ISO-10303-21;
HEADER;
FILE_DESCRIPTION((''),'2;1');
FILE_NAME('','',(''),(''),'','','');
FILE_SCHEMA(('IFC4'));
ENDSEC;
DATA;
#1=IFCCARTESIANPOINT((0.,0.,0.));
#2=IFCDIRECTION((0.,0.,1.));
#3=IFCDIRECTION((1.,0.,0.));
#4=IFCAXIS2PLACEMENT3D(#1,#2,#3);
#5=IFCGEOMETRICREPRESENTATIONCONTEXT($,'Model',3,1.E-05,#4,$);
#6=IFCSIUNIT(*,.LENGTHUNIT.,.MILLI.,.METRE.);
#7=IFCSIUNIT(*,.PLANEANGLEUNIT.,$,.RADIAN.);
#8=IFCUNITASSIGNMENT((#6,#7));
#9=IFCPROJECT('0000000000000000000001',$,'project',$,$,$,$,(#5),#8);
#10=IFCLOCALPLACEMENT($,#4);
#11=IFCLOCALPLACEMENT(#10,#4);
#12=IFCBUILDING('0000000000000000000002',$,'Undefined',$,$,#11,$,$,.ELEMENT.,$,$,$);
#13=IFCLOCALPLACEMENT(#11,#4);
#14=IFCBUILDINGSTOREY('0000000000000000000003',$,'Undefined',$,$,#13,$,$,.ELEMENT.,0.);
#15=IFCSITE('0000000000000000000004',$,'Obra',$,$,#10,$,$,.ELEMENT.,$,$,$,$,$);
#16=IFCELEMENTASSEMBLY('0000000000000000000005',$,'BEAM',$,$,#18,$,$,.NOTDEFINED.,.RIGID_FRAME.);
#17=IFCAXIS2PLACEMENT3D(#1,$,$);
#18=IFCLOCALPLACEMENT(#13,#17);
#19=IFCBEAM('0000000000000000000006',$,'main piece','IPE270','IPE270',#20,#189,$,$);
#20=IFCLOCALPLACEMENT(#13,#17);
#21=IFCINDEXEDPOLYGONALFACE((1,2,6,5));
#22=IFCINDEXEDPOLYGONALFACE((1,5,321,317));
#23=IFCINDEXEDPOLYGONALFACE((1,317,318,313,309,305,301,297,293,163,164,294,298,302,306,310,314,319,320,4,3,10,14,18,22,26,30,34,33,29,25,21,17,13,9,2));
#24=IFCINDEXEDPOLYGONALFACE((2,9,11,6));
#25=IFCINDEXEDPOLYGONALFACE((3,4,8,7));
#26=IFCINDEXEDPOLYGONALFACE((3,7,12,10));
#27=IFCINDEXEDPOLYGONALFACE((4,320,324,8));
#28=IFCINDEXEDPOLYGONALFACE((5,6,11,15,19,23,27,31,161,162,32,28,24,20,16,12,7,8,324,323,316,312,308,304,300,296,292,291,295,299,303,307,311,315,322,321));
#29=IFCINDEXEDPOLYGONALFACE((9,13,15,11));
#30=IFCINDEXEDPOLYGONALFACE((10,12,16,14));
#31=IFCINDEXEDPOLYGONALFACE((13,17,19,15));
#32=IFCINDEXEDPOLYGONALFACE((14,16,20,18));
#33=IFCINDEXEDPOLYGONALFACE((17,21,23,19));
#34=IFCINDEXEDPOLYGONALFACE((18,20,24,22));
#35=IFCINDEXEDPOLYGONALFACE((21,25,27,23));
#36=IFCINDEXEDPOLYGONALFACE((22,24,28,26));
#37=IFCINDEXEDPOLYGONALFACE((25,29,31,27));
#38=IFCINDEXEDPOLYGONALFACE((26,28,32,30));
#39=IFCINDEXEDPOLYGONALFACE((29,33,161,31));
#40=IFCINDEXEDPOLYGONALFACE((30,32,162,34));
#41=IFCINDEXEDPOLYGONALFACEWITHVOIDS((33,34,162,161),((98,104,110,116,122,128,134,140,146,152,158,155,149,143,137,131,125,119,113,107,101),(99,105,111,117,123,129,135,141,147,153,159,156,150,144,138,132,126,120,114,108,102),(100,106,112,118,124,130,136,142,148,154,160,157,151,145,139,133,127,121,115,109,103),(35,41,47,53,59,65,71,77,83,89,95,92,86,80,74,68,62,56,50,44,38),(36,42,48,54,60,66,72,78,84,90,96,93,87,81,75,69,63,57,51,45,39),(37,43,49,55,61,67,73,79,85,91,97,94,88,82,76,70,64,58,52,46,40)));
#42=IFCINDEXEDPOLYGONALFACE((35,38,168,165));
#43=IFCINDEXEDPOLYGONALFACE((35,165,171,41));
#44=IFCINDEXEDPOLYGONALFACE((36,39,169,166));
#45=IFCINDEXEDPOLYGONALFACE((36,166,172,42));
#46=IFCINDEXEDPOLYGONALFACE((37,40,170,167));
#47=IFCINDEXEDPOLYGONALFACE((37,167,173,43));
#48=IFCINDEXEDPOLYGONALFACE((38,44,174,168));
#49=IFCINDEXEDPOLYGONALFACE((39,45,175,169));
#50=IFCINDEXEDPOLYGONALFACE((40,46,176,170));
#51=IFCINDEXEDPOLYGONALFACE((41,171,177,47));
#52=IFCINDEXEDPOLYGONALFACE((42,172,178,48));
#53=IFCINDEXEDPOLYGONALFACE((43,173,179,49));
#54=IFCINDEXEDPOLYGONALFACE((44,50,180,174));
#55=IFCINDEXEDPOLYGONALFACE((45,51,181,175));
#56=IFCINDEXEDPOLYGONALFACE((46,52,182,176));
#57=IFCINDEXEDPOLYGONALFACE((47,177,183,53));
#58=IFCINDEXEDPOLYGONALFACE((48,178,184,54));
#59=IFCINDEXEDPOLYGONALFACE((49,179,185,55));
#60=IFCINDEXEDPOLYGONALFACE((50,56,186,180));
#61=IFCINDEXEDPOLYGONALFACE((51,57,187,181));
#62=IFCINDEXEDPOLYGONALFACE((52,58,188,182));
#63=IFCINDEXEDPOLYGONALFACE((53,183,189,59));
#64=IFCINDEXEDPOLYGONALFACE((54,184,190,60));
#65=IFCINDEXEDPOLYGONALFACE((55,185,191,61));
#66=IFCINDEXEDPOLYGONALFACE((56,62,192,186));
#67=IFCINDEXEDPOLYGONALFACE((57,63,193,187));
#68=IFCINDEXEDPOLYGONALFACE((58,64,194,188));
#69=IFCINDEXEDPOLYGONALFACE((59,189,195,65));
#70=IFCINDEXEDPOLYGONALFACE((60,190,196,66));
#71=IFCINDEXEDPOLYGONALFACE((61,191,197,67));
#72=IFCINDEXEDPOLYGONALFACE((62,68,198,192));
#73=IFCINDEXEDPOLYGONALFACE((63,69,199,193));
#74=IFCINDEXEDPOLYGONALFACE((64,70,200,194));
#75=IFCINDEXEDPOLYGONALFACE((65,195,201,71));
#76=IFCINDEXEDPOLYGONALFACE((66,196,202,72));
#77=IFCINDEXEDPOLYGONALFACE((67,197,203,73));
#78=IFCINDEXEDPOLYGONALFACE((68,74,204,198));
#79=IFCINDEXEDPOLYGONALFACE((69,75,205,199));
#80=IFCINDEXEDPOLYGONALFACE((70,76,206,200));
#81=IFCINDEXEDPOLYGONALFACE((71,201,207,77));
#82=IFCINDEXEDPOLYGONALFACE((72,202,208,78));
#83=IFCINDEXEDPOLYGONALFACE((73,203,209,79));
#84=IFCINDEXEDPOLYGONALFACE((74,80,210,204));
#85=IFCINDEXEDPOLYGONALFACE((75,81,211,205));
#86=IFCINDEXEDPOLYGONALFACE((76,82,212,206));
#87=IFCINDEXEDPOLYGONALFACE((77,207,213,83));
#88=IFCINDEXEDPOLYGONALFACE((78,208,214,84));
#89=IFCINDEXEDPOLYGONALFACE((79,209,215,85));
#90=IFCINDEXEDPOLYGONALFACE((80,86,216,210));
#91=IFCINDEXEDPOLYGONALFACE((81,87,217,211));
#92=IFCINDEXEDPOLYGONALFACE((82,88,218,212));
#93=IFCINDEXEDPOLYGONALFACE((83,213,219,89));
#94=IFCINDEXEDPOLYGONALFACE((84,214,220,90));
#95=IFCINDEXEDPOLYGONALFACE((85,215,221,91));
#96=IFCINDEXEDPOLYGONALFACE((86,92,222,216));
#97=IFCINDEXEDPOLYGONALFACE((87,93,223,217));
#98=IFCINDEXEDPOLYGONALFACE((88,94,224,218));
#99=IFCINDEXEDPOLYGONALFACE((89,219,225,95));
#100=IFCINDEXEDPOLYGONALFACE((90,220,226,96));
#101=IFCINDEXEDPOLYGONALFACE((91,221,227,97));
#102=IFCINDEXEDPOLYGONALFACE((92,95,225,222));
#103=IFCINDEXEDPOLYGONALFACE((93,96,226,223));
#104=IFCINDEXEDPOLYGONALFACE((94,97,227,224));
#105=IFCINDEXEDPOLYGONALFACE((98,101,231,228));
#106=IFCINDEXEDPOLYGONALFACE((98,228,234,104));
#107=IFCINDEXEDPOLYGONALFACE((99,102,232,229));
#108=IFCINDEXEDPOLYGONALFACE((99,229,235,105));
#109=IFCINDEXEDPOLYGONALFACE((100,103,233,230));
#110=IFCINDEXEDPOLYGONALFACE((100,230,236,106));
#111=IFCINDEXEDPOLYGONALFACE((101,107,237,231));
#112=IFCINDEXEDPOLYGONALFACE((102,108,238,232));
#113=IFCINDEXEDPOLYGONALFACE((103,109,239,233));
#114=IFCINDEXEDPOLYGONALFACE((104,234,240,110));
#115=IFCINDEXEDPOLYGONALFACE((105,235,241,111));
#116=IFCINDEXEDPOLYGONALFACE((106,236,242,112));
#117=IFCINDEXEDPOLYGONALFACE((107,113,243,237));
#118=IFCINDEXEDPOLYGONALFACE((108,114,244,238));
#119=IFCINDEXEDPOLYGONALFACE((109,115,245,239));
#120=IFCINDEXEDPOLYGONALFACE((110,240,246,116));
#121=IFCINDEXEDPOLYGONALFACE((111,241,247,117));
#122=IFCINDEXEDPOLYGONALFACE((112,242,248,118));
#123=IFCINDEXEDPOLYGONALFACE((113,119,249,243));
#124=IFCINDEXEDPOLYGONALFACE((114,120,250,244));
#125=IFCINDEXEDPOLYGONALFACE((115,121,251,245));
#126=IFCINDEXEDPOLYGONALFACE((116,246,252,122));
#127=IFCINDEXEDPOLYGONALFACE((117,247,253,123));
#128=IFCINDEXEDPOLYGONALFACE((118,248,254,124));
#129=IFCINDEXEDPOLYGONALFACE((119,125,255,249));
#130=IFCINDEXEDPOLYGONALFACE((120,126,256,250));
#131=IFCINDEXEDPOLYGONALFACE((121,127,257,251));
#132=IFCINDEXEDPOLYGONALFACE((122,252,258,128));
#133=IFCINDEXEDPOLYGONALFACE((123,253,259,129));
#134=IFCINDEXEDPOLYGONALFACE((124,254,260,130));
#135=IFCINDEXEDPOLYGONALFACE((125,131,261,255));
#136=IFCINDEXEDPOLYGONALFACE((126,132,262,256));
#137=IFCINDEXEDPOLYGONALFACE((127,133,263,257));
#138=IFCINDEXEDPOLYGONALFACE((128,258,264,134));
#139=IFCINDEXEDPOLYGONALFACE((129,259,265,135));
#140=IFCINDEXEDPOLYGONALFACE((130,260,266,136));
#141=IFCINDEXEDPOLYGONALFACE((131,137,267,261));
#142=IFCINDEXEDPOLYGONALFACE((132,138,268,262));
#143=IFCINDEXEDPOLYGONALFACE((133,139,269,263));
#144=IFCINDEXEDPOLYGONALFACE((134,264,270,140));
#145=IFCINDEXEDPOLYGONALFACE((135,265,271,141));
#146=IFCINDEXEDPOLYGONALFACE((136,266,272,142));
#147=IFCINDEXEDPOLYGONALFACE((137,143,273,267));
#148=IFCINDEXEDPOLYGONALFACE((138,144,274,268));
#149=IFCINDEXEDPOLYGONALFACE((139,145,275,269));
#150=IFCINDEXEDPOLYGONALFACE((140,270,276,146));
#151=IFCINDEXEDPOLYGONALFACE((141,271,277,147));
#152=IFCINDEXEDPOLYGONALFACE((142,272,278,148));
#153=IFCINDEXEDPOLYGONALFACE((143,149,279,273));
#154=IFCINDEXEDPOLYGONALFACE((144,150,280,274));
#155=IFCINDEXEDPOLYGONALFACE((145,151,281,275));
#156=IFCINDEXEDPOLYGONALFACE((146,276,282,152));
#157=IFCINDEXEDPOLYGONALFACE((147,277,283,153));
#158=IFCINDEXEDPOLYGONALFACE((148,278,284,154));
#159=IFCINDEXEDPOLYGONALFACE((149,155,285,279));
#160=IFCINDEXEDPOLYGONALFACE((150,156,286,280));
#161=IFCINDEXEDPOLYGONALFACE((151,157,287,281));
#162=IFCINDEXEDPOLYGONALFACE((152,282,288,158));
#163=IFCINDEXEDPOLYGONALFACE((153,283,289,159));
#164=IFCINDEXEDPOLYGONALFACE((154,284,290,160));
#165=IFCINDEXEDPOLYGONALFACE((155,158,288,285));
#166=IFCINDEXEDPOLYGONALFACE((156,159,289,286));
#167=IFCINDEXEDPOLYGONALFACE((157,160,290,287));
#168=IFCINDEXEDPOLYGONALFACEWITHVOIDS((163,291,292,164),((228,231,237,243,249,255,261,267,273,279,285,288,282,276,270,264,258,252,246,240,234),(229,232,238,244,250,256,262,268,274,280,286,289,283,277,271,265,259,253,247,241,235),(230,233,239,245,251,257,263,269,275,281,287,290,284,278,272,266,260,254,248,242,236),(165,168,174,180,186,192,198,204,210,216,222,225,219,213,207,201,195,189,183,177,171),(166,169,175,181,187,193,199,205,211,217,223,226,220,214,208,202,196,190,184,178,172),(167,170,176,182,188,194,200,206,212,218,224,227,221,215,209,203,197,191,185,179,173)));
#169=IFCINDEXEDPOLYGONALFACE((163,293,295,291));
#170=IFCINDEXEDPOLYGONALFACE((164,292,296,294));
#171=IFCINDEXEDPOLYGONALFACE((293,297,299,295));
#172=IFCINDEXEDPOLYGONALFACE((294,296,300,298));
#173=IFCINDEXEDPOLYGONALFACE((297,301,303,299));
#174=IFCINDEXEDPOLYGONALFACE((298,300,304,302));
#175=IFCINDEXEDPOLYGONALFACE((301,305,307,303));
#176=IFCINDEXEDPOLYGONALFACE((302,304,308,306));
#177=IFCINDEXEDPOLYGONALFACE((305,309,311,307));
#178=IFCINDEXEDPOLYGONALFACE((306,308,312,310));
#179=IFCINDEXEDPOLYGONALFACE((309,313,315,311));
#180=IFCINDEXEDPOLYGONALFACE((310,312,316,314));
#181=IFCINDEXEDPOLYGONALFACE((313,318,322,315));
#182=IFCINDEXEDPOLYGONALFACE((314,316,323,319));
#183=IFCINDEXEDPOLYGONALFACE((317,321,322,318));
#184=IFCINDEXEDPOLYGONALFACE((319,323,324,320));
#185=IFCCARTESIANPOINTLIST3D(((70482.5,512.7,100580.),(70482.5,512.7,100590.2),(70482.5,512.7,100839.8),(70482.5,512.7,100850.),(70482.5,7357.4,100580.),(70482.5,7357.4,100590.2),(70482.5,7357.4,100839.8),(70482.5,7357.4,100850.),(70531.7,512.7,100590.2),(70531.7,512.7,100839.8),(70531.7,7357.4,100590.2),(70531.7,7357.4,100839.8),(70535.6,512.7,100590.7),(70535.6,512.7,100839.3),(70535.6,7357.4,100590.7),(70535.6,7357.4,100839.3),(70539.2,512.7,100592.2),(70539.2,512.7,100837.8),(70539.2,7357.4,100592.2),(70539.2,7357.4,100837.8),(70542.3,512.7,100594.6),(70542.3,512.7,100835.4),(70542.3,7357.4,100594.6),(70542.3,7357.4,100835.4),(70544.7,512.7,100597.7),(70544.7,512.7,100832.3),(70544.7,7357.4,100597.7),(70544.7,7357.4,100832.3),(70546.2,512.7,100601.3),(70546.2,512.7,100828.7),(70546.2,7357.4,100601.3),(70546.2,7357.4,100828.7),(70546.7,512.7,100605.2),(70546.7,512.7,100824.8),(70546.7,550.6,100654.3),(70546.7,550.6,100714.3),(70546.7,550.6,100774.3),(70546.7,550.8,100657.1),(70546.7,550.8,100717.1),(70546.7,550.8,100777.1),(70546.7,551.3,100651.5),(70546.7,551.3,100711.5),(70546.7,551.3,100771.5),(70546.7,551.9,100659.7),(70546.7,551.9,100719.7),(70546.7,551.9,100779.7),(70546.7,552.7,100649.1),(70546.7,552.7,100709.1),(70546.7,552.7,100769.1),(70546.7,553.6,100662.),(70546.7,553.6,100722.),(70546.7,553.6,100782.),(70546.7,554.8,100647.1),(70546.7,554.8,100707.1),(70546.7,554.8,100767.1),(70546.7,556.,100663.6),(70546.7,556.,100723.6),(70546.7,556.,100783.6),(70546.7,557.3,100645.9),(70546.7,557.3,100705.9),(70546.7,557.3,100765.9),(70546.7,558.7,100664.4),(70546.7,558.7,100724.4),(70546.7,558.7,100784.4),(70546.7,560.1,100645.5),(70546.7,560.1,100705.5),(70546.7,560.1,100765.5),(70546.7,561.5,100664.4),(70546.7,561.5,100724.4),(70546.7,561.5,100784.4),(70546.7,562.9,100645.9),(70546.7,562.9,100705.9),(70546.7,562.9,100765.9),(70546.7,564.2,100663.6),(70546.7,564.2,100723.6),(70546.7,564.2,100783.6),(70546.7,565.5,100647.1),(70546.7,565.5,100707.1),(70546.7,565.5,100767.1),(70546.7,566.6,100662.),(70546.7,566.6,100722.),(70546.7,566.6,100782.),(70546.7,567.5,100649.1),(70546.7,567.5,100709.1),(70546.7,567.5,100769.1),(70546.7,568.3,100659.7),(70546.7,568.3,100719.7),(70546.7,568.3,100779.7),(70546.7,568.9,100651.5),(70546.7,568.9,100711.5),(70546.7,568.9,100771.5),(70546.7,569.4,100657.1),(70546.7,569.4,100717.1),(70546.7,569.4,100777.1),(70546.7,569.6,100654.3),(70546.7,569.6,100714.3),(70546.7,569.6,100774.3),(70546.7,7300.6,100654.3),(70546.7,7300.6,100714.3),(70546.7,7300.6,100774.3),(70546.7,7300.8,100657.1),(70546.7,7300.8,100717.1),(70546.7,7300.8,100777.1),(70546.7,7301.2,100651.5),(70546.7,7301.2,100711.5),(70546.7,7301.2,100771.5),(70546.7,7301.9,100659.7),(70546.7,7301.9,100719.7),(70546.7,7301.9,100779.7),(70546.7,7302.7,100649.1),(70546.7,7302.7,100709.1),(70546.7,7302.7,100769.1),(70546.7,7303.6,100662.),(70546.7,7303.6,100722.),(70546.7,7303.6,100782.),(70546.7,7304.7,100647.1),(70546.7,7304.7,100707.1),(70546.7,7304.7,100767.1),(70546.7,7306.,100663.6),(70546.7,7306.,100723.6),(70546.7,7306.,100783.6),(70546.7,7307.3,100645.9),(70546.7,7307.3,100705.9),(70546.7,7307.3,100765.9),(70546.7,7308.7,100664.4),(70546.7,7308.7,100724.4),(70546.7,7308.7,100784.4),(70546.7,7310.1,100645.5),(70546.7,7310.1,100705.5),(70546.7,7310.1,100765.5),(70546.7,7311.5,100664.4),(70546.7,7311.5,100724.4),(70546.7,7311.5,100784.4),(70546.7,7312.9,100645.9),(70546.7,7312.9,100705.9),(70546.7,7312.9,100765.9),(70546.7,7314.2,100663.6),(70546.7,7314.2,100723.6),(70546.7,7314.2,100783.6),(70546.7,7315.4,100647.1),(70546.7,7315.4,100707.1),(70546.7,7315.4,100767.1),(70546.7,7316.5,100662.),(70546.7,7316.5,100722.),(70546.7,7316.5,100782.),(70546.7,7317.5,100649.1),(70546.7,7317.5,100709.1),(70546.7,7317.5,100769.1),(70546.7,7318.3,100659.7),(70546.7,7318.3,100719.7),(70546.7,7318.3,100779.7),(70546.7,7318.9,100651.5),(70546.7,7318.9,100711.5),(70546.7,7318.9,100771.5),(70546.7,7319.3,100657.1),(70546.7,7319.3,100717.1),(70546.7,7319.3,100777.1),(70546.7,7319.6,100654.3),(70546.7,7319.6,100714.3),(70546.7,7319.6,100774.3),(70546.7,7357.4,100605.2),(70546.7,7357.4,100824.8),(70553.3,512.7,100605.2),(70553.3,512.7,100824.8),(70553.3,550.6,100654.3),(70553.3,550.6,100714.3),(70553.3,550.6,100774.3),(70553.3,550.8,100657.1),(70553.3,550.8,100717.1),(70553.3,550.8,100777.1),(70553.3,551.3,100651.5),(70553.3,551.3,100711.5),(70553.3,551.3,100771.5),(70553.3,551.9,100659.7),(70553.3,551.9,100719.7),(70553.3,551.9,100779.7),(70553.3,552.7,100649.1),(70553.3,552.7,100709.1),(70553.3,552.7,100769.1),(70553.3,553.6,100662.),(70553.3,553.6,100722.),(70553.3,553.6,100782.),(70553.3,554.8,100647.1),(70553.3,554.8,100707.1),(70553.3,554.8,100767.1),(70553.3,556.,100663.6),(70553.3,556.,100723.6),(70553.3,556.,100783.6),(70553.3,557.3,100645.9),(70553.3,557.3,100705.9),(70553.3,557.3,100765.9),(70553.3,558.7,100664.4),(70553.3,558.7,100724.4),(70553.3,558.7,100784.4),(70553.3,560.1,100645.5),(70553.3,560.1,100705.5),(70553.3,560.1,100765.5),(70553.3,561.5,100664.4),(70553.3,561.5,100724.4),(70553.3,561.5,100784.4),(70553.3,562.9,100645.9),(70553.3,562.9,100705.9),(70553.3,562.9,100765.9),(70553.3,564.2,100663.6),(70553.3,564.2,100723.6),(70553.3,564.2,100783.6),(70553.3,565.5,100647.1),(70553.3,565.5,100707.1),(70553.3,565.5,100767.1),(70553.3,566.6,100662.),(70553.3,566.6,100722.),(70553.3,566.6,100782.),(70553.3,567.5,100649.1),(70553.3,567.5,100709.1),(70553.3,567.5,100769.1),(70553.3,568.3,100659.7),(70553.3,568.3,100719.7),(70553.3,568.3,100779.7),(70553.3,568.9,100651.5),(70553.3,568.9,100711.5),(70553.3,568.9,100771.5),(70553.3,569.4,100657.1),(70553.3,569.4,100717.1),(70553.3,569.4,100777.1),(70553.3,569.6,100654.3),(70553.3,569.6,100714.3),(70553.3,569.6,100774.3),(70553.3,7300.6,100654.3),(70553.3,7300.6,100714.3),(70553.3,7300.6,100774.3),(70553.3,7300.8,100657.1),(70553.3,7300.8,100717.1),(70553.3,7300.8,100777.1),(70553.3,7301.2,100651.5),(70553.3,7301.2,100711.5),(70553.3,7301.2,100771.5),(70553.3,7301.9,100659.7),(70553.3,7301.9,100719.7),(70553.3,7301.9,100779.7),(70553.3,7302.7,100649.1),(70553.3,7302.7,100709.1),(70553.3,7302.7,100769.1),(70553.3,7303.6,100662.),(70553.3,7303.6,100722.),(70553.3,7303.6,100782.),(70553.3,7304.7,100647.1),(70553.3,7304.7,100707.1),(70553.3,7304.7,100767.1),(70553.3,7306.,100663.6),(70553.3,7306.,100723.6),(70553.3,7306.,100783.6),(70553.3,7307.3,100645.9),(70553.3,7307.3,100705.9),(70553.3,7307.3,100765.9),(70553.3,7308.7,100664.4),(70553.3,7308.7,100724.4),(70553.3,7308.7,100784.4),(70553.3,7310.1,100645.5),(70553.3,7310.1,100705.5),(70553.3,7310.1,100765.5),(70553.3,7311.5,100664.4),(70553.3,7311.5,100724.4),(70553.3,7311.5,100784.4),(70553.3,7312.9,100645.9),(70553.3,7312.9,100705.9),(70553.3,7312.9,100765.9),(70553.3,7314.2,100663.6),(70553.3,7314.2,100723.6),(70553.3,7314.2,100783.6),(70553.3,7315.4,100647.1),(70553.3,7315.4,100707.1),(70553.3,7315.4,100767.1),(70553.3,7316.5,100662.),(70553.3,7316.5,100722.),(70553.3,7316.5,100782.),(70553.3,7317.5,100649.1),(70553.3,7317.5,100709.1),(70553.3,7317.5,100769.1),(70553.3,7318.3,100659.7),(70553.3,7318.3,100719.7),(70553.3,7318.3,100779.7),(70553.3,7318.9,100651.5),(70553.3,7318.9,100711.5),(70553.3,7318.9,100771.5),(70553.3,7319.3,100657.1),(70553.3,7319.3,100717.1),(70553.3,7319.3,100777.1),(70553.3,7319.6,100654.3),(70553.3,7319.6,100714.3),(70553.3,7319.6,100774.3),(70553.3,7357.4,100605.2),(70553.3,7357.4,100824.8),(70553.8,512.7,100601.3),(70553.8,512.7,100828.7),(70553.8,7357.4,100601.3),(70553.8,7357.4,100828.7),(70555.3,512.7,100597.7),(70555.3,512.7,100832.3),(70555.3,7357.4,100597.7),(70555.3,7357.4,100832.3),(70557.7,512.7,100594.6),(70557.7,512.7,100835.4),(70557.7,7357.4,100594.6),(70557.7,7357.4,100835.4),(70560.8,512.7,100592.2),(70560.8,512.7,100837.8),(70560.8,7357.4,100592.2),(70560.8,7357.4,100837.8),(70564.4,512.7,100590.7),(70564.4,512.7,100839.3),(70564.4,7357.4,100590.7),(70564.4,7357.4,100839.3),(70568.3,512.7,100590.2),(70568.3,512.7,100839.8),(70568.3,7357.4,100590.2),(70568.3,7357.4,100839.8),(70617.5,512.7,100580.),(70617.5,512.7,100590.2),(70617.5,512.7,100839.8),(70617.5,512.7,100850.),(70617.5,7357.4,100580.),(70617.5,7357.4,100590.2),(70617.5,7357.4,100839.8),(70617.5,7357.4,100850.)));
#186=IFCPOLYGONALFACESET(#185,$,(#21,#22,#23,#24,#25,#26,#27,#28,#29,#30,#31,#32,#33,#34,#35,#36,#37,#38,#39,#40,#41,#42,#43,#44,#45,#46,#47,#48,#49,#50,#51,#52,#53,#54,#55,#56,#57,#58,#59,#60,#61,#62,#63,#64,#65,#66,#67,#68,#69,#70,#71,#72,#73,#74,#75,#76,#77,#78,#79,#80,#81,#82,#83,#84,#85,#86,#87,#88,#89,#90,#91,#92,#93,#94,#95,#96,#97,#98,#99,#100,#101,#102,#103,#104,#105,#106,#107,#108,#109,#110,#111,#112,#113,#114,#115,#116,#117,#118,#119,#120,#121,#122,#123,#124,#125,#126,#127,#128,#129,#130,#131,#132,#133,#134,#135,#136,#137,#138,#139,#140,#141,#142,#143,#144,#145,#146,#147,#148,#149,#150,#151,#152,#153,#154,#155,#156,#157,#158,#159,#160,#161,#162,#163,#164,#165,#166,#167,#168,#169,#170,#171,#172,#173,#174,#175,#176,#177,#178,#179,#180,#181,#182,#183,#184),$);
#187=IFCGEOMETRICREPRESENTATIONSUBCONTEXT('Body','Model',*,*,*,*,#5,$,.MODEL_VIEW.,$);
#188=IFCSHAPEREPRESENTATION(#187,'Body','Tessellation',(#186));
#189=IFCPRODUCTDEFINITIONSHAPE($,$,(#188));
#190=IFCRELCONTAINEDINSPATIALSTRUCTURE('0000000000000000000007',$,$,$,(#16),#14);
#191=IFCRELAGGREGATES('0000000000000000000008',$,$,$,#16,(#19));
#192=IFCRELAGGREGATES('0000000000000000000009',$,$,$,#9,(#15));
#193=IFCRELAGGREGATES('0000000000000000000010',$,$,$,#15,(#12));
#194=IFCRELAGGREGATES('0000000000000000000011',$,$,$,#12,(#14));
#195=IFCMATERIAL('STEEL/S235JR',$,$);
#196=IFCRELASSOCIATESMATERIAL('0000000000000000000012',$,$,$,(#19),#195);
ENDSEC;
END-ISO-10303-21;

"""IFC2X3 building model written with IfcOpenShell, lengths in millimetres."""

from ifc_helpers import new_model, si_unit, frame, origin_with_axes, origin_2d_with_axis, place, context, subcontext, project, spatial, circle, i_section, extrude, clip, halfspace, source, transform, mapped, material, element, aggregate, save


model = new_model("IFC2X3")

# Units and contexts
model_context = context("Model", 3, precision=1e-05, world=origin_with_axes())
body_context = subcontext(model_context, "Body", "Model", "MODEL_VIEW")
ifc_project = project(units=[si_unit("LENGTHUNIT", "METRE", prefix="MILLI"), si_unit("PLANEANGLEUNIT", "RADIAN")], contexts=[model_context])

# Site, building, storey
site_placement = place(None, origin_with_axes())
site = spatial("IfcSite", under=ifc_project, at=site_placement, Name="Obra", CompositionType="ELEMENT")
building_placement = place(site_placement, origin_with_axes())
building = spatial("IfcBuilding", under=site, at=building_placement, Name="Undefined", CompositionType="ELEMENT")
storey_placement = place(building_placement, origin_with_axes())
storey = spatial("IfcBuildingStorey", under=building, at=storey_placement, Name="Undefined", CompositionType="ELEMENT", Elevation=0.0)

# Shared definitions
ifc_material = material(Name="STEEL/S235JR")
shared_shape_1 = source(origin_with_axes(), body_context, "Body", "SweptSolid", [
    extrude(circle(Radius=9.5, at=origin_2d_with_axis()), frame((0.0, -3.4, 0.0), z_axis=(0.0, 1.0, 0.0), x_axis=(1.0, 0.0, 0.0)), (0.0, 0.0, 1.0), 6.8),
])
shared_shape_2 = source(origin_with_axes(), body_context, "Body", "SweptSolid", [
    extrude(circle(Radius=9.5, at=origin_2d_with_axis()), frame((0.0, -3.4, 0.0), z_axis=(0.0, 1.0, 0.0), x_axis=(1.0, 0.0, 0.0)), (0.0, 0.0, 1.0), 6.8),
])

# Element assembly, beam, openings
assembly_1_placement = place(storey_placement, origin_with_axes())
assembly_1 = element("IfcElementAssembly", 1, at=assembly_1_placement, inside=storey, Name="BEAM", AssemblyPlace="NOTDEFINED", PredefinedType="RIGID_FRAME")
beam_1_placement = place(assembly_1_placement, frame((70550.0, 512.7, 100715.0), z_axis=(0.0, 0.0, 1.0), x_axis=(0.0, 1.0, 0.0)))
beam_1 = element("IfcBeam", 2, at=beam_1_placement, material=ifc_material, Name="main piece", Description="IPE270", ObjectType="IPE270", context=body_context, shape_type="Clipping", body=[
    clip(clip(extrude(i_section(OverallWidth=135.0, OverallDepth=270.0, WebThickness=6.6, FlangeThickness=10.2, FilletRadius=15.0, at=origin_2d_with_axis()), frame((6844.7, 0.0, 0.0), z_axis=(-1.0, 0.0, 0.0), x_axis=(0.0, -1.0, 0.0)), (0.0, 0.0, 1.0), 6844.7), halfspace(frame((-2.2, 60.0, -120.0), z_axis=(-1.0, -0.000021, 0.0), x_axis=(0.0, 0.0, 1.0)), False)), halfspace(frame((6846.9, -60.0, -120.0), z_axis=(1.0, 0.0, 0.0), x_axis=(0.0, 0.0, 1.0)), False)),
])
opening_1_placement = place(assembly_1_placement, frame((70550.0, 510.1, 100835.0), z_axis=(-0.000002, 1.0, 0.0), x_axis=(0.0, 0.0, -1.0)))
element("IfcOpeningElement", 3, at=opening_1_placement, cuts=beam_1, ObjectType="Opening", context=body_context, shape_type="MappedRepresentation", body=[
    mapped(shared_shape_1, transform((60.0, 0.0, 50.0))),
    mapped(shared_shape_1, transform((120.0, 0.0, 50.0))),
    mapped(shared_shape_1, transform((180.0, 0.0, 50.0))),
])
opening_2_placement = place(assembly_1_placement, frame((70550.0, 7360.1, 100835.0), z_axis=(-0.000019, -1.0, 0.0), x_axis=(0.0, 0.0, -1.0)))
element("IfcOpeningElement", 4, at=opening_2_placement, cuts=beam_1, ObjectType="Opening", context=body_context, shape_type="MappedRepresentation", body=[
    mapped(shared_shape_2, transform((60.0, 0.0, 50.0))),
    mapped(shared_shape_2, transform((120.0, 0.0, 50.0))),
    mapped(shared_shape_2, transform((180.0, 0.0, 50.0))),
])
aggregate(assembly_1, [beam_1])

save(model, "model.ifc")
